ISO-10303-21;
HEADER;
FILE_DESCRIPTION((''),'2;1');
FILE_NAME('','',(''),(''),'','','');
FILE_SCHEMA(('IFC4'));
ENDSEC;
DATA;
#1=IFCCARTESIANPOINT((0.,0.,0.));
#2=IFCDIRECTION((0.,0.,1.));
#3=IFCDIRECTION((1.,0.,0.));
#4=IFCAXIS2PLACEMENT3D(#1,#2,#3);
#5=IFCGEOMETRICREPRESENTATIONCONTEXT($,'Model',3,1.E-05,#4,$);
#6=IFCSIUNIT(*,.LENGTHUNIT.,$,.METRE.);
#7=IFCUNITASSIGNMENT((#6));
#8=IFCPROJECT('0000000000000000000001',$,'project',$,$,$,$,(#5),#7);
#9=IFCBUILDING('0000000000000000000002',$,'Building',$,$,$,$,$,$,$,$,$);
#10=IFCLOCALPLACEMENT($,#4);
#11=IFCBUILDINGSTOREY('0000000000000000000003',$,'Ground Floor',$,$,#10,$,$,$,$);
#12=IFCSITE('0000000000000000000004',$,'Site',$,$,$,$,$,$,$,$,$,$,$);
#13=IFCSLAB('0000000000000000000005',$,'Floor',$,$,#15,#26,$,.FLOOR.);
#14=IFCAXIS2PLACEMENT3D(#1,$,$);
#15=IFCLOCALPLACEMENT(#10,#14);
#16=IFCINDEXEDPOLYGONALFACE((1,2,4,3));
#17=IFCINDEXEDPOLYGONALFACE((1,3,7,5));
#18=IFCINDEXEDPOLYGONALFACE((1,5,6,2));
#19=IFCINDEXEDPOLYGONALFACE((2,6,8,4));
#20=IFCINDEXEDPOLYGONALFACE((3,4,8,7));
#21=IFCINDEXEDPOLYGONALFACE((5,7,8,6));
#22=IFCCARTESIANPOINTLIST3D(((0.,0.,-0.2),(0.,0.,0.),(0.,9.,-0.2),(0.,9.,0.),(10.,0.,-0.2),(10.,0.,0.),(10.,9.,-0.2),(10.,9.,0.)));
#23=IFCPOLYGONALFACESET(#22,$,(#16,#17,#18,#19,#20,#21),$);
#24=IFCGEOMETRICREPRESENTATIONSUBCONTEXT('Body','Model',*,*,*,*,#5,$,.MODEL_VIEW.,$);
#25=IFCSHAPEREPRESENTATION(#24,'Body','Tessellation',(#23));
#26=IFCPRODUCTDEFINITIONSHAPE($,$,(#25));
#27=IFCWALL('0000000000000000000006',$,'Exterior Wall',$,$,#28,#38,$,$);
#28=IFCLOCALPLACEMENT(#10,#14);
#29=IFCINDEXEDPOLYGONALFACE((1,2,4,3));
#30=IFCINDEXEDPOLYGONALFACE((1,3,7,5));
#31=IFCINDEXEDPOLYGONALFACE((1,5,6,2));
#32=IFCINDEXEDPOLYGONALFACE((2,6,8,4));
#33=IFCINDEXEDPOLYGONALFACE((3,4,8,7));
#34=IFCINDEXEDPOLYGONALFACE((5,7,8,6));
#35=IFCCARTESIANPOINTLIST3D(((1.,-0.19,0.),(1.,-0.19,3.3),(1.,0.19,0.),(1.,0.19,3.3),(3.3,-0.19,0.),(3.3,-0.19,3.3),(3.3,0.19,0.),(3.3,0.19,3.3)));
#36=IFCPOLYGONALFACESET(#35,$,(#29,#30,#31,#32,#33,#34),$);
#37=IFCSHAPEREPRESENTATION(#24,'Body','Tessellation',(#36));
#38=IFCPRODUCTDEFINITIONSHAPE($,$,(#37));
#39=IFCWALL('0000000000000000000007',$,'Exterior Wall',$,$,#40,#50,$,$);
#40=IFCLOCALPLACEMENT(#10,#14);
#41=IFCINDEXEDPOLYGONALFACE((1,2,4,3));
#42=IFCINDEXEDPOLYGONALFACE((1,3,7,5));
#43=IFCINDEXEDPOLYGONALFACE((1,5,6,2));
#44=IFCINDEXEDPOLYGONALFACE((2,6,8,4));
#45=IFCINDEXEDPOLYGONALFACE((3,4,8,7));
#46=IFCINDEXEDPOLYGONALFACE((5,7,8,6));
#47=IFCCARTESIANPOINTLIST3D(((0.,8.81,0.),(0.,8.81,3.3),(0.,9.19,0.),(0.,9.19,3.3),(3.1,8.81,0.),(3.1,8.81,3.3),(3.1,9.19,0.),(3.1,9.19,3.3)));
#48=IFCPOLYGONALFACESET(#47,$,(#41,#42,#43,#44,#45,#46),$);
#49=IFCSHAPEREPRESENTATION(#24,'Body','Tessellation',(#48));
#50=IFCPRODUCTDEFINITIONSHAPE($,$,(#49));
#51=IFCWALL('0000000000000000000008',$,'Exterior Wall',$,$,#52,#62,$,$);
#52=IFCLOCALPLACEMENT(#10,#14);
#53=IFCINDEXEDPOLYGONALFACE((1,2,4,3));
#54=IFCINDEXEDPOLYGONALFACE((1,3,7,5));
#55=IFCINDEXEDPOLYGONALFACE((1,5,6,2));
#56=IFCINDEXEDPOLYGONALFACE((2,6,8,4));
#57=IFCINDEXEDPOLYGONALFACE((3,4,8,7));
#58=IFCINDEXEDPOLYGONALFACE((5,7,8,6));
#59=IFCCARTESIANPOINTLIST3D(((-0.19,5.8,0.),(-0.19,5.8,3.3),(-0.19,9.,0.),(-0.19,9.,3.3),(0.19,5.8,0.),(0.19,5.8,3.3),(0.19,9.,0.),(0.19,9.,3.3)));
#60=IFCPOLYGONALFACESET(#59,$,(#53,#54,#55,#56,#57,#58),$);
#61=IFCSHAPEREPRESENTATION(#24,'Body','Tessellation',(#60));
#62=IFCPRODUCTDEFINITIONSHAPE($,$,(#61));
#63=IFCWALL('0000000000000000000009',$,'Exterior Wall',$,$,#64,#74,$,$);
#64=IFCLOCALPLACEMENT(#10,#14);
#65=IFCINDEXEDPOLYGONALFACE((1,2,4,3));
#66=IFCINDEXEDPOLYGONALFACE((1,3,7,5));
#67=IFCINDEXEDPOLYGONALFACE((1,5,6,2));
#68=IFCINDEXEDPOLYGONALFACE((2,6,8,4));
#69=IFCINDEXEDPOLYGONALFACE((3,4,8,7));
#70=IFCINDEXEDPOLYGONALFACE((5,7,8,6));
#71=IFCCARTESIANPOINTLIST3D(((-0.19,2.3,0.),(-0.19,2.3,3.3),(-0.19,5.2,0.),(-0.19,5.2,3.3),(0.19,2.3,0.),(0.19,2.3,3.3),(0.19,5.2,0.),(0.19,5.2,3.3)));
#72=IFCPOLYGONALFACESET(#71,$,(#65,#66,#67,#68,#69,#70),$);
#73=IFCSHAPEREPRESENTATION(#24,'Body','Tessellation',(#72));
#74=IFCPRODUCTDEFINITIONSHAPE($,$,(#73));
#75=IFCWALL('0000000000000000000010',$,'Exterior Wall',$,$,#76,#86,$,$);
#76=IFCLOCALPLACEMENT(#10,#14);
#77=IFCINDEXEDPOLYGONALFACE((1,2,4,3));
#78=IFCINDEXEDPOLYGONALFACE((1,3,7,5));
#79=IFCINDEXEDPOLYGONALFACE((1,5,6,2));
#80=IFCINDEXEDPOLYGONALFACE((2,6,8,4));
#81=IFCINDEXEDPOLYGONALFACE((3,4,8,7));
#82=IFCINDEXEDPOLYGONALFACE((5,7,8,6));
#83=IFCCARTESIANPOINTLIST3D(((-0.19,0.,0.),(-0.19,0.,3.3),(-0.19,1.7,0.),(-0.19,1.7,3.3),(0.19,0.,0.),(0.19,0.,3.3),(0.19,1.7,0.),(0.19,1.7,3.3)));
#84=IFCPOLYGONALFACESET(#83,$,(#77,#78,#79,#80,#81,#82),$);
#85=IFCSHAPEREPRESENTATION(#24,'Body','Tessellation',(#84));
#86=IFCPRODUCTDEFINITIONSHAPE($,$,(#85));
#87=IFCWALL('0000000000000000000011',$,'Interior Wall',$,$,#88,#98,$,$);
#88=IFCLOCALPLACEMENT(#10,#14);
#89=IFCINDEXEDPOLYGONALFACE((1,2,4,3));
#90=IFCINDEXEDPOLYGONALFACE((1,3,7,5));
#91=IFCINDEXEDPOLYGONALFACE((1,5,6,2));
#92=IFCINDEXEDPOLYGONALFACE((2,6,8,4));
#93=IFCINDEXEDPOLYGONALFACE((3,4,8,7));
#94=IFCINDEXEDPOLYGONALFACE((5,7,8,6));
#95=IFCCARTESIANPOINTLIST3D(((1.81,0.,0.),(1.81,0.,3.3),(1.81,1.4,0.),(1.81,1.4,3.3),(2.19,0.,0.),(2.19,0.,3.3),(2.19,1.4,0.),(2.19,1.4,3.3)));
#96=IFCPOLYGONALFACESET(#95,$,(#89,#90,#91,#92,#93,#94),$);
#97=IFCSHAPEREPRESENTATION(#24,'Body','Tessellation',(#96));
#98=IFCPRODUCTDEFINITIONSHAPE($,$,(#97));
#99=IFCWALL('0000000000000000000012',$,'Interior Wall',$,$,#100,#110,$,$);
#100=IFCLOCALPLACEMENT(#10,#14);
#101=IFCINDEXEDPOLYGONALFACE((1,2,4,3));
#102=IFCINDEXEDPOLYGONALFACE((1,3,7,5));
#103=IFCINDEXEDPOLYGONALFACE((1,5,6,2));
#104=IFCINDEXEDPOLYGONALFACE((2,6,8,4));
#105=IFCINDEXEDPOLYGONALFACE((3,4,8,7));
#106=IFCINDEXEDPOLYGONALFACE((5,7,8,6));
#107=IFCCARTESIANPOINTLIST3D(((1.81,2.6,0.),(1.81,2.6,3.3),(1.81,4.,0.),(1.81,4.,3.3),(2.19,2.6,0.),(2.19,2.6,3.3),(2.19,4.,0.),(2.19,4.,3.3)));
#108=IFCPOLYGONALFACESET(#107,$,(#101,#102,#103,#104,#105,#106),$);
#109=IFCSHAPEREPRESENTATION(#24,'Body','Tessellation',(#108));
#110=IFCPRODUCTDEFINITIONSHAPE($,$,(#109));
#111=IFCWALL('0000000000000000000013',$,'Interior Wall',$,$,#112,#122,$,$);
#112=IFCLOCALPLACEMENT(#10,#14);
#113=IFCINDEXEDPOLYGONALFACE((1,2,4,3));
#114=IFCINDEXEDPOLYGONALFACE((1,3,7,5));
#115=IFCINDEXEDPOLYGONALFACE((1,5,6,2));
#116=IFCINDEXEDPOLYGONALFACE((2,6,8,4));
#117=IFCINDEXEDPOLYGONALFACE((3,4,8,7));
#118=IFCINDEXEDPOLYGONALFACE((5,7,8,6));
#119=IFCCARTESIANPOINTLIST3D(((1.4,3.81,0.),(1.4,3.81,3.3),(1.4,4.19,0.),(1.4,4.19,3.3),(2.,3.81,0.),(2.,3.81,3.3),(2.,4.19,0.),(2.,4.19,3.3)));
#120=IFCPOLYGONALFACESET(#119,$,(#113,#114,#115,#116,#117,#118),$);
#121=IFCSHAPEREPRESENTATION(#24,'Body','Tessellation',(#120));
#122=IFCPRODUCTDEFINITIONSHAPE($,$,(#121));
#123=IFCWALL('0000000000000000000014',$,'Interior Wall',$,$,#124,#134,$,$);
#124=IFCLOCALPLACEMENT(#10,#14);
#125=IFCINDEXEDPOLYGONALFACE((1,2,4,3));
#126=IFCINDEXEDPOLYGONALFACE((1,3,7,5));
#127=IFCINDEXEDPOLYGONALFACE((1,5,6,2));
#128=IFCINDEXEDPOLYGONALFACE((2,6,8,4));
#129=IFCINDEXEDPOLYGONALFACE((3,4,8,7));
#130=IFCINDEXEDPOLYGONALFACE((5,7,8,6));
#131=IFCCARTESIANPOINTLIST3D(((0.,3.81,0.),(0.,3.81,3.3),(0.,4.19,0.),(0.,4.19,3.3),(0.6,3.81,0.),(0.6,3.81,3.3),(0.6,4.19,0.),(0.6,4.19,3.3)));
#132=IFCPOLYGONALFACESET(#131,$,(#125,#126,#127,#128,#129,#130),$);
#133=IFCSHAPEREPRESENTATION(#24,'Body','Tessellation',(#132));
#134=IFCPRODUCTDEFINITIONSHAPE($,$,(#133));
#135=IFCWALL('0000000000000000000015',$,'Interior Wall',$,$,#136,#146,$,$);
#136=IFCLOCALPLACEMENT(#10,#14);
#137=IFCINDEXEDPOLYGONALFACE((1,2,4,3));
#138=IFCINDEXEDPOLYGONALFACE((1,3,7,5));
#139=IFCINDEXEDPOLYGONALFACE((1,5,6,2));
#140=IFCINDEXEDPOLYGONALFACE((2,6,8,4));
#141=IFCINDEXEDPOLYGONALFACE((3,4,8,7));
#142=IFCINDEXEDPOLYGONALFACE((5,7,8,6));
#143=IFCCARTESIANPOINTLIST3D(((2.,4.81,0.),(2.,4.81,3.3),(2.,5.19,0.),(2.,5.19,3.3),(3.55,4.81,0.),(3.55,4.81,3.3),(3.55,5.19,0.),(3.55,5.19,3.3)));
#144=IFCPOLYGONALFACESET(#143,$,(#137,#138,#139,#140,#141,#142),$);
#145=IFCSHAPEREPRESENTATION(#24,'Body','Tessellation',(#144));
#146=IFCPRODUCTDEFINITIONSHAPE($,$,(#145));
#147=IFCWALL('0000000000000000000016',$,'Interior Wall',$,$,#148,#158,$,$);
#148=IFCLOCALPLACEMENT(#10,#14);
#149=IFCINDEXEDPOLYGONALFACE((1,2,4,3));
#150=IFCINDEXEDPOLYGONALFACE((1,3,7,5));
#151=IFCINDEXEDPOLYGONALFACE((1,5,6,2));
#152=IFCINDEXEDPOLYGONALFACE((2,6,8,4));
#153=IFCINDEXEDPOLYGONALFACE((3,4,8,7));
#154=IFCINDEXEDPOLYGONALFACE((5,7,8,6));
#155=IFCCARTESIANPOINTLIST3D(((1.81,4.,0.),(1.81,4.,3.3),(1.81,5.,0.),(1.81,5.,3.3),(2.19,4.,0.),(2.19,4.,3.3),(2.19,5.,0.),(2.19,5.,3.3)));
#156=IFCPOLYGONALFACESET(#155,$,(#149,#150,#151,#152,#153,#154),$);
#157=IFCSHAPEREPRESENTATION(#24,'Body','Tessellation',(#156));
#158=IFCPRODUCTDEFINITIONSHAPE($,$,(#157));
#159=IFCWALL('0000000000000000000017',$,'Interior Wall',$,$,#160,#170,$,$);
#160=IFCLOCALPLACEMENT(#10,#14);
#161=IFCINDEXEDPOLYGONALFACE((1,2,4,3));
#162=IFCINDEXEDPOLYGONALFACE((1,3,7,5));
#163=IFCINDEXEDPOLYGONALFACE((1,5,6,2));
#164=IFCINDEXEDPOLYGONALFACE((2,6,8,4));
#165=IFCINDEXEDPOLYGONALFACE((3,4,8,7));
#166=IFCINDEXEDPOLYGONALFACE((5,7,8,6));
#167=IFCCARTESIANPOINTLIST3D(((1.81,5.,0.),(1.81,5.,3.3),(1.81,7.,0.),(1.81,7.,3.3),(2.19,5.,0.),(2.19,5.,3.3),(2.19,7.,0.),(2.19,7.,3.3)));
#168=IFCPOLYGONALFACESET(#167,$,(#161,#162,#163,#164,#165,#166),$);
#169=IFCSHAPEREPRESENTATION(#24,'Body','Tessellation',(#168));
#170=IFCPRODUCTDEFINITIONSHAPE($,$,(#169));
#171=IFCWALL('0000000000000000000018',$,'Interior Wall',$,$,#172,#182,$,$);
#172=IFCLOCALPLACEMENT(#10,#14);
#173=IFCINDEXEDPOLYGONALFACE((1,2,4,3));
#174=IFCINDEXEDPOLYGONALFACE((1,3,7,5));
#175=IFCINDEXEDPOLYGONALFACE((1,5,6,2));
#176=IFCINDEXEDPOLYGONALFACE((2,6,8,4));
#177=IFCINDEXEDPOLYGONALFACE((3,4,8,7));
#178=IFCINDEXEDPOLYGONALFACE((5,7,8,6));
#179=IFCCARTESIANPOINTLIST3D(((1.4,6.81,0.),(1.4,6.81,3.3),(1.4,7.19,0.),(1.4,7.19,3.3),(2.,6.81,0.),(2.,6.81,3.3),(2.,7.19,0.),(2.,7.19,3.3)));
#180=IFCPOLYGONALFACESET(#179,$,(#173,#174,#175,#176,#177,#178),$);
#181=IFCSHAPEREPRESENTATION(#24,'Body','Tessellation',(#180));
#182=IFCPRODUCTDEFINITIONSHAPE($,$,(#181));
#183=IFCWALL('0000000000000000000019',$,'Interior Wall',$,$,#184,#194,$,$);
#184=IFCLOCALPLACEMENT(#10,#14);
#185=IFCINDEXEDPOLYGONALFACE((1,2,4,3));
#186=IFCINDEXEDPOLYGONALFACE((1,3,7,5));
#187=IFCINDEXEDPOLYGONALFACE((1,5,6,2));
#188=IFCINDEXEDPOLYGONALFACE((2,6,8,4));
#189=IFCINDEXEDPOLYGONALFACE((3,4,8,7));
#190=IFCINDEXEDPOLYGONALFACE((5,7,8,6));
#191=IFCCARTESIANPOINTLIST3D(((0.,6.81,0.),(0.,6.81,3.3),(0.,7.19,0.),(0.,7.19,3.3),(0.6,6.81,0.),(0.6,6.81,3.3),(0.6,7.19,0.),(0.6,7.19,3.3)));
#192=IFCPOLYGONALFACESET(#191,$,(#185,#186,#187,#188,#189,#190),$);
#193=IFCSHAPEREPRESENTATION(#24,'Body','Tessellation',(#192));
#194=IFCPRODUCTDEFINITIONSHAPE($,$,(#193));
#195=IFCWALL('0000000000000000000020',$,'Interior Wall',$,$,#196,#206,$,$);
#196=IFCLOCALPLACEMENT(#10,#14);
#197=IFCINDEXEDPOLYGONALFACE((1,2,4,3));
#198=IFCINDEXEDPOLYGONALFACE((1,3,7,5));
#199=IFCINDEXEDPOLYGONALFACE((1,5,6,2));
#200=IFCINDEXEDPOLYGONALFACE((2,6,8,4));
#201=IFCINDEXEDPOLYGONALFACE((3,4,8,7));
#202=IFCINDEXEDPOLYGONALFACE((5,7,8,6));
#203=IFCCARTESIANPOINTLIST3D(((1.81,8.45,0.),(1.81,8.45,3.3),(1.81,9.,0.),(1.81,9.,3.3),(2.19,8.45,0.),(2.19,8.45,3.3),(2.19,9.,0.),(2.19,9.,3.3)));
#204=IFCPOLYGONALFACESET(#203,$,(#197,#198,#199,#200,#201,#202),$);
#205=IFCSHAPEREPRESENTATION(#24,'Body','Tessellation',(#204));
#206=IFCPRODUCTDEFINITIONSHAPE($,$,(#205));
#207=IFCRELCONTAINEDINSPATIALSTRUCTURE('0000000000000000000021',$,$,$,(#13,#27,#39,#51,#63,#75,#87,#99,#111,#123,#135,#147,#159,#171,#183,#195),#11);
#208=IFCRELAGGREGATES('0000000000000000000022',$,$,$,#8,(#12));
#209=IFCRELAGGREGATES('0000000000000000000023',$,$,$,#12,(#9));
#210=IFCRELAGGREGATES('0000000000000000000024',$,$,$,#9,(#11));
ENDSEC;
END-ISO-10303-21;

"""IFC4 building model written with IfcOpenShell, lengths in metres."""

from ifc_helpers import new_model, si_unit, frame, origin_with_axes, place, context, subcontext, project, spatial, indexed_curve, outline, extrude, element, save


model = new_model("IFC4")

# Units and contexts
model_context = context("Model", 3, precision=1e-05, world=origin_with_axes())
body_context = subcontext(model_context, "Body", "Model", "MODEL_VIEW")
ifc_project = project(units=[si_unit("LENGTHUNIT", "METRE")], contexts=[model_context])

# Site, building, storey
site = spatial("IfcSite", under=ifc_project, Name="Site")
building = spatial("IfcBuilding", under=site, Name="Building")
storey_placement = place(None, origin_with_axes())
storey = spatial("IfcBuildingStorey", under=building, at=storey_placement, Name="Ground Floor")

# Slab
slab_placement = place(storey_placement, frame((0.0, 0.0, -0.2), z_axis=(0.0, 0.0, 1.0), x_axis=(1.0, 0.0, 0.0)))
element("IfcSlab", 1, at=slab_placement, inside=storey, Name="Floor", PredefinedType="FLOOR", context=body_context, shape_type="SweptSolid", body=[
    extrude(outline(indexed_curve([(0.0, 0.0), (10.0, 0.0), (10.0, 9.0), (0.0, 9.0)])), None, (0.0, 0.0, 1.0), 0.2),
])

# Walls
wall_1_placement = place(storey_placement, frame((1.0, 0.0, 0.0), z_axis=(0.0, 0.0, 1.0), x_axis=(1.0, 0.0, 0.0)))
element("IfcWall", 2, at=wall_1_placement, inside=storey, Name="Exterior Wall", context=body_context, shape_type="SweptSolid", body=[
    extrude(outline(indexed_curve([(0.0, 0.0), (0.0, 0.38), (2.3, 0.38), (2.3, 0.0), (0.0, 0.0)], self_intersect=False)), frame((0.0, -0.19, 0.0), z_axis=(0.0, 0.0, 1.0), x_axis=(1.0, 0.0, 0.0)), (0.0, 0.0, 1.0), 3.3),
])
wall_2_placement = place(storey_placement, frame((3.1, 9.0, 0.0), z_axis=(0.0, 0.0, 1.0), x_axis=(-1.0, 0.0, 0.0)))
element("IfcWall", 3, at=wall_2_placement, inside=storey, Name="Exterior Wall", context=body_context, shape_type="SweptSolid", body=[
    extrude(outline(indexed_curve([(0.0, 0.0), (0.0, 0.38), (3.1, 0.38), (3.1, 0.0), (0.0, 0.0)], self_intersect=False)), frame((0.0, -0.19, 0.0), z_axis=(0.0, 0.0, 1.0), x_axis=(1.0, 0.0, 0.0)), (0.0, 0.0, 1.0), 3.3),
])
wall_3_placement = place(storey_placement, frame((0.0, 9.0, 0.0), z_axis=(0.0, 0.0, 1.0), x_axis=(0.0, -1.0, 0.0)))
element("IfcWall", 4, at=wall_3_placement, inside=storey, Name="Exterior Wall", context=body_context, shape_type="SweptSolid", body=[
    extrude(outline(indexed_curve([(0.0, 0.0), (0.0, 0.38), (3.2, 0.38), (3.2, 0.0), (0.0, 0.0)], self_intersect=False)), frame((0.0, -0.19, 0.0), z_axis=(0.0, 0.0, 1.0), x_axis=(1.0, 0.0, 0.0)), (0.0, 0.0, 1.0), 3.3),
])
wall_4_placement = place(storey_placement, frame((0.0, 5.2, 0.0), z_axis=(0.0, 0.0, 1.0), x_axis=(0.0, -1.0, 0.0)))
element("IfcWall", 5, at=wall_4_placement, inside=storey, Name="Exterior Wall", context=body_context, shape_type="SweptSolid", body=[
    extrude(outline(indexed_curve([(0.0, 0.0), (0.0, 0.38), (2.9, 0.38), (2.9, 0.0), (0.0, 0.0)], self_intersect=False)), frame((0.0, -0.19, 0.0), z_axis=(0.0, 0.0, 1.0), x_axis=(1.0, 0.0, 0.0)), (0.0, 0.0, 1.0), 3.3),
])
wall_5_placement = place(storey_placement, frame((0.0, 1.7, 0.0), z_axis=(0.0, 0.0, 1.0), x_axis=(0.0, -1.0, 0.0)))
element("IfcWall", 6, at=wall_5_placement, inside=storey, Name="Exterior Wall", context=body_context, shape_type="SweptSolid", body=[
    extrude(outline(indexed_curve([(0.0, 0.0), (0.0, 0.38), (1.7, 0.38), (1.7, 0.0), (0.0, 0.0)], self_intersect=False)), frame((0.0, -0.19, 0.0), z_axis=(0.0, 0.0, 1.0), x_axis=(1.0, 0.0, 0.0)), (0.0, 0.0, 1.0), 3.3),
])
for number, where, z_axis, x_axis, name in (
    (7, (2.0, 0.0, 0.0), (0.0, 0.0, 1.0), (0.0, 1.0, 0.0), "Interior Wall"),
    (8, (2.0, 2.6, 0.0), (0.0, 0.0, 1.0), (0.0, 1.0, 0.0), "Interior Wall"),
):
    element("IfcWall", number, at=place(storey_placement, frame(where, z_axis=z_axis, x_axis=x_axis)), inside=storey, Name=name, context=body_context, shape_type="SweptSolid", body=[
        extrude(outline(indexed_curve([(0.0, 0.0), (0.0, 0.38), (1.4, 0.38), (1.4, 0.0), (0.0, 0.0)], self_intersect=False)), frame((0.0, -0.19, 0.0), z_axis=(0.0, 0.0, 1.0), x_axis=(1.0, 0.0, 0.0)), (0.0, 0.0, 1.0), 3.3),
    ])
for number, where, z_axis, x_axis, name in (
    (9, (2.0, 4.0, 0.0), (0.0, 0.0, 1.0), (-1.0, 0.0, 0.0), "Interior Wall"),
    (10, (0.6, 4.0, 0.0), (0.0, 0.0, 1.0), (-1.0, 0.0, 0.0), "Interior Wall"),
):
    element("IfcWall", number, at=place(storey_placement, frame(where, z_axis=z_axis, x_axis=x_axis)), inside=storey, Name=name, context=body_context, shape_type="SweptSolid", body=[
        extrude(outline(indexed_curve([(0.0, 0.0), (0.0, 0.38), (0.6, 0.38), (0.6, 0.0), (0.0, 0.0)], self_intersect=False)), frame((0.0, -0.19, 0.0), z_axis=(0.0, 0.0, 1.0), x_axis=(1.0, 0.0, 0.0)), (0.0, 0.0, 1.0), 3.3),
    ])
wall_6_placement = place(storey_placement, frame((3.55, 5.0, 0.0), z_axis=(0.0, 0.0, 1.0), x_axis=(-1.0, 0.0, 0.0)))
element("IfcWall", 11, at=wall_6_placement, inside=storey, Name="Interior Wall", context=body_context, shape_type="SweptSolid", body=[
    extrude(outline(indexed_curve([(0.0, 0.0), (0.0, 0.38), (1.55, 0.38), (1.55, 0.0), (0.0, 0.0)], self_intersect=False)), frame((0.0, -0.19, 0.0), z_axis=(0.0, 0.0, 1.0), x_axis=(1.0, 0.0, 0.0)), (0.0, 0.0, 1.0), 3.3),
])
wall_7_placement = place(storey_placement, frame((2.0, 5.0, 0.0), z_axis=(0.0, 0.0, 1.0), x_axis=(0.0, -1.0, 0.0)))
element("IfcWall", 12, at=wall_7_placement, inside=storey, Name="Interior Wall", context=body_context, shape_type="SweptSolid", body=[
    extrude(outline(indexed_curve([(0.0, 0.0), (0.0, 0.38), (1.0, 0.38), (1.0, 0.0), (0.0, 0.0)], self_intersect=False)), frame((0.0, -0.19, 0.0), z_axis=(0.0, 0.0, 1.0), x_axis=(1.0, 0.0, 0.0)), (0.0, 0.0, 1.0), 3.3),
])
wall_8_placement = place(storey_placement, frame((2.0, 5.0, 0.0), z_axis=(0.0, 0.0, 1.0), x_axis=(0.0, 1.0, 0.0)))
element("IfcWall", 13, at=wall_8_placement, inside=storey, Name="Interior Wall", context=body_context, shape_type="SweptSolid", body=[
    extrude(outline(indexed_curve([(0.0, 0.0), (0.0, 0.38), (2.0, 0.38), (2.0, 0.0), (0.0, 0.0)], self_intersect=False)), frame((0.0, -0.19, 0.0), z_axis=(0.0, 0.0, 1.0), x_axis=(1.0, 0.0, 0.0)), (0.0, 0.0, 1.0), 3.3),
])
for number, where, z_axis, x_axis, name in (
    (14, (2.0, 7.0, 0.0), (0.0, 0.0, 1.0), (-1.0, 0.0, 0.0), "Interior Wall"),
    (15, (0.6, 7.0, 0.0), (0.0, 0.0, 1.0), (-1.0, 0.0, 0.0), "Interior Wall"),
):
    element("IfcWall", number, at=place(storey_placement, frame(where, z_axis=z_axis, x_axis=x_axis)), inside=storey, Name=name, context=body_context, shape_type="SweptSolid", body=[
        extrude(outline(indexed_curve([(0.0, 0.0), (0.0, 0.38), (0.6, 0.38), (0.6, 0.0), (0.0, 0.0)], self_intersect=False)), frame((0.0, -0.19, 0.0), z_axis=(0.0, 0.0, 1.0), x_axis=(1.0, 0.0, 0.0)), (0.0, 0.0, 1.0), 3.3),
    ])
wall_9_placement = place(storey_placement, frame((2.0, 9.0, 0.0), z_axis=(0.0, 0.0, 1.0), x_axis=(0.0, -1.0, 0.0)))
element("IfcWall", 16, at=wall_9_placement, inside=storey, Name="Interior Wall", context=body_context, shape_type="SweptSolid", body=[
    extrude(outline(indexed_curve([(0.0, 0.0), (0.0, 0.38), (0.55, 0.38), (0.55, 0.0), (0.0, 0.0)], self_intersect=False)), frame((0.0, -0.19, 0.0), z_axis=(0.0, 0.0, 1.0), x_axis=(1.0, 0.0, 0.0)), (0.0, 0.0, 1.0), 3.3),
])

save(model, "model.ifc")
